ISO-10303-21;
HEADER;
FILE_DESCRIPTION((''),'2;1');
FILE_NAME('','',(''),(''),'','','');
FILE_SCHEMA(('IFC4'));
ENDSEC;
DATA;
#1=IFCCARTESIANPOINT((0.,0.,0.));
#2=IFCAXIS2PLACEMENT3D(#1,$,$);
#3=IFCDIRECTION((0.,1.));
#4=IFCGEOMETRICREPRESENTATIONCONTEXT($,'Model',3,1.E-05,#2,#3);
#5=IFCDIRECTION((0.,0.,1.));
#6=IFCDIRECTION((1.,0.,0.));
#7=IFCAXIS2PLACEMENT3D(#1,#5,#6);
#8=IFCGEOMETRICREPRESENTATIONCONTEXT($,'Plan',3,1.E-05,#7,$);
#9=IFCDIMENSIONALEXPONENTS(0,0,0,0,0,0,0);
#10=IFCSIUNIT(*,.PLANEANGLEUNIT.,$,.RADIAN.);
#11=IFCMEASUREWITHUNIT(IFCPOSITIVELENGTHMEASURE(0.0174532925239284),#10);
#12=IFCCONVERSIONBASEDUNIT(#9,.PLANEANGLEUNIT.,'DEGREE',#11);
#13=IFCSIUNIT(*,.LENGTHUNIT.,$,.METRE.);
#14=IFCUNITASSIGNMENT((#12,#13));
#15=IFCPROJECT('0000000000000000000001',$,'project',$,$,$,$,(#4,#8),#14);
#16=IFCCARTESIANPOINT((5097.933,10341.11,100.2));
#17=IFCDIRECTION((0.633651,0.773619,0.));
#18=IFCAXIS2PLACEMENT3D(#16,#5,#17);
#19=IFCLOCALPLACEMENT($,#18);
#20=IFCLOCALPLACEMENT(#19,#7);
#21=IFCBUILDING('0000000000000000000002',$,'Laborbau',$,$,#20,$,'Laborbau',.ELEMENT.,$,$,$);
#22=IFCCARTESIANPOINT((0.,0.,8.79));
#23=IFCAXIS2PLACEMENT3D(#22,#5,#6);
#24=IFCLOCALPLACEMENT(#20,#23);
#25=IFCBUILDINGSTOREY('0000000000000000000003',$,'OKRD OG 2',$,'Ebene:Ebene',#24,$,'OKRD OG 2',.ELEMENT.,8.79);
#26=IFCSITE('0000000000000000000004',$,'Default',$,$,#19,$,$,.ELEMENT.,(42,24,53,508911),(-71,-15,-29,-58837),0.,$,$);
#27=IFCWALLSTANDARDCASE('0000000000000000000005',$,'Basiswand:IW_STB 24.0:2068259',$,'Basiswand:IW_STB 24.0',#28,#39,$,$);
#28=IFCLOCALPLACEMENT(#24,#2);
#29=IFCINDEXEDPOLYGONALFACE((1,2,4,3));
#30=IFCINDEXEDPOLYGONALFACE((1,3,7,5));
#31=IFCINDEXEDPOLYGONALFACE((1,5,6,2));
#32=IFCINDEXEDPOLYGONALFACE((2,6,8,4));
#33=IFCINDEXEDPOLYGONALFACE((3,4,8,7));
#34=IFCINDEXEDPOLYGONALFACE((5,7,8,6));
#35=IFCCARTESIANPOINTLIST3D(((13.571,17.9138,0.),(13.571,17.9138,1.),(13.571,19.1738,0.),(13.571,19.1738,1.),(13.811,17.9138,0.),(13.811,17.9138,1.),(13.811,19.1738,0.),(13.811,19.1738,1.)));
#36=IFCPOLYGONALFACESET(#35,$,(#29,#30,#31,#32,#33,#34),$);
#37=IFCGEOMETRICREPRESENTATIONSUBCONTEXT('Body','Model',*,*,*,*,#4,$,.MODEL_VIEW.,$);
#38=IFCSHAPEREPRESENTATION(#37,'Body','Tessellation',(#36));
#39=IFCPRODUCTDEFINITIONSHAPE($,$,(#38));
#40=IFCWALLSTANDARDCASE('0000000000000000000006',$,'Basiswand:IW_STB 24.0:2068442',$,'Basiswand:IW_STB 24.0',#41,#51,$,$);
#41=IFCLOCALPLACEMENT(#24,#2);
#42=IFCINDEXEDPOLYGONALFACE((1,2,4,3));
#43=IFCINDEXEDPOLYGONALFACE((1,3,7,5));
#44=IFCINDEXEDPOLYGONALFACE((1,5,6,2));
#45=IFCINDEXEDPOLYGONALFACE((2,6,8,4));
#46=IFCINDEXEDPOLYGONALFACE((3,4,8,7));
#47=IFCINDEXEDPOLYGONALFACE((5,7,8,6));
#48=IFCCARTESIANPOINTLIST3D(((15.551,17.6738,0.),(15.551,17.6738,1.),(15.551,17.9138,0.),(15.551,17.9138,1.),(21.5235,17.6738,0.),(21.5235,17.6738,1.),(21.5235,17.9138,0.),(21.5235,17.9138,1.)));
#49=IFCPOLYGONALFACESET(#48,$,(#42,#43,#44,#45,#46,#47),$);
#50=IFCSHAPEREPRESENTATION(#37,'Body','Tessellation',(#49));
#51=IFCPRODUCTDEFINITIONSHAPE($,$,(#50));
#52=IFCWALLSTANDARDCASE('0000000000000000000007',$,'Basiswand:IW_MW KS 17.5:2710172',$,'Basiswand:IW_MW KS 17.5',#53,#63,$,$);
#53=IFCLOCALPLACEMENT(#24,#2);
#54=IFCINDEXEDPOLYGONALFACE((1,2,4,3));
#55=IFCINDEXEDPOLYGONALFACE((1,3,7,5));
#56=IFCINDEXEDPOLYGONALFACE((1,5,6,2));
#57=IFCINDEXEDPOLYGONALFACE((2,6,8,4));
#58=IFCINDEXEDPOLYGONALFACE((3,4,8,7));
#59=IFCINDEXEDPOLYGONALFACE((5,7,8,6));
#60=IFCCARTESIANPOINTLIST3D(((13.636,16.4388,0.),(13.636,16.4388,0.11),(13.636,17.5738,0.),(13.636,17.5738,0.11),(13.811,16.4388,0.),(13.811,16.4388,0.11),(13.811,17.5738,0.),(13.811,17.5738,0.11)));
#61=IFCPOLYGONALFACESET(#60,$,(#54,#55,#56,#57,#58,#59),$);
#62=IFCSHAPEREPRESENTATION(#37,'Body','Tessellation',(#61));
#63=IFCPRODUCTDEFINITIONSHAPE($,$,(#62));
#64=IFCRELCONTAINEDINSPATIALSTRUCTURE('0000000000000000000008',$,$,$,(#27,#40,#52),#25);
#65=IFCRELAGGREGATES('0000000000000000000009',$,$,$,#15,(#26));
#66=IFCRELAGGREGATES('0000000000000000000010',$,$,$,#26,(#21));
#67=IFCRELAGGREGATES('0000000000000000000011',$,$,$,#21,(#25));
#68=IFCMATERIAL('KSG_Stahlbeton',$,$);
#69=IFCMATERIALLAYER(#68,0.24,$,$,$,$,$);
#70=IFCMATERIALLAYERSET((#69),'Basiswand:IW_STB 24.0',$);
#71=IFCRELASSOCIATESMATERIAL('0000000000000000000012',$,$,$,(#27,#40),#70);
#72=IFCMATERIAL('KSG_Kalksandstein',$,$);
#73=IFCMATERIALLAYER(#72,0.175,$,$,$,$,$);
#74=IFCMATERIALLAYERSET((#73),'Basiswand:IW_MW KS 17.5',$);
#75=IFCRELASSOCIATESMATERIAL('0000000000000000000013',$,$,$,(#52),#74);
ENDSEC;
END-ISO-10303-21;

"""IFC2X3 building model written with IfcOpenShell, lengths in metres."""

from ifc_helpers import new_model, entity, si_unit, converted_unit, direction, frame, frame_2d, origin, origin_with_axes, place, context, subcontext, project, spatial, rectangle, extrude, material, layer, layer_set, layer_usage, element, save


model = new_model("IFC2X3")

# Units and contexts
model_context = context("Model", 3, precision=1e-05, world=origin(), true_north=direction((0.0, 1.0)))
plan_context = context("Plan", 3, precision=1e-05, world=origin_with_axes())
body_context = subcontext(model_context, "Body", "Model", "MODEL_VIEW")
ifc_project = project(units=[converted_unit("PLANEANGLEUNIT", "DEGREE", entity("IfcPositiveLengthMeasure", 0.0174532925239284), si_unit("PLANEANGLEUNIT", "RADIAN"), dimensions=[0, 0, 0, 0, 0, 0, 0]), si_unit("LENGTHUNIT", "METRE")], contexts=[model_context, plan_context])

# Site, building, storey
site_placement = place(None, frame((5097.933, 10341.11, 100.2), z_axis=(0.0, 0.0, 1.0), x_axis=(0.633651, 0.773619, 0.0)))
site = spatial("IfcSite", under=ifc_project, at=site_placement, Name="Default", CompositionType="ELEMENT", RefLatitude=(42, 24, 53, 508911), RefLongitude=(-71, -15, -29, -58837), RefElevation=0.0)
building_placement = place(site_placement, origin_with_axes())
building = spatial("IfcBuilding", under=site, at=building_placement, Name="Laborbau", LongName="Laborbau", CompositionType="ELEMENT")
storey_placement = place(building_placement, frame((0.0, 0.0, 8.79), z_axis=(0.0, 0.0, 1.0), x_axis=(1.0, 0.0, 0.0)))
storey = spatial("IfcBuildingStorey", under=building, at=storey_placement, Name="OKRD OG 2", ObjectType="Ebene:Ebene", LongName="OKRD OG 2", CompositionType="ELEMENT", Elevation=8.79)

# Shared definitions
ifc_material_1 = material(Name="KSG_Kalksandstein")
ifc_layer_1 = layer(ifc_material_1, 0.175)
ifc_layer_set_1 = layer_set([ifc_layer_1], Name="Basiswand:IW_MW KS 17.5")

# Walls
ifc_material_2 = material(Name="KSG_Stahlbeton")
ifc_layer_2 = layer(ifc_material_2, 0.24)
ifc_layer_set_2 = layer_set([ifc_layer_2], Name="Basiswand:IW_STB 24.0")
ifc_layer_usage_1 = layer_usage(ifc_layer_set_2, "AXIS2", "NEGATIVE", 0.12)
wall_1_placement = place(storey_placement, frame((13.691, 19.1738, 0.0), z_axis=(0.0, 0.0, 1.0), x_axis=(0.0, -1.0, 0.0)))
element("IfcWallStandardCase", 1, at=wall_1_placement, inside=storey, material=ifc_layer_usage_1, Name="Basiswand:IW_STB 24.0:2068259", ObjectType="Basiswand:IW_STB 24.0", context=body_context, shape_type="SweptSolid", body=[
    extrude(rectangle(XDim=1.26, YDim=0.24, at=frame_2d((0.63, 0.0), x_axis=(-1.0, 0.0))), origin(), (0.0, 0.0, 1.0), 1.0),
])
ifc_layer_usage_2 = layer_usage(ifc_layer_set_2, "AXIS2", "NEGATIVE", 0.12)
wall_2_placement = place(storey_placement, frame((15.551, 17.7938, 0.0), z_axis=(0.0, 0.0, 1.0), x_axis=(1.0, 0.0, 0.0)))
element("IfcWallStandardCase", 2, at=wall_2_placement, inside=storey, material=ifc_layer_usage_2, Name="Basiswand:IW_STB 24.0:2068442", ObjectType="Basiswand:IW_STB 24.0", context=body_context, shape_type="SweptSolid", body=[
    extrude(rectangle(XDim=5.9725, YDim=0.24, at=frame_2d((2.9863, 0.0), x_axis=(-1.0, 0.0))), origin(), (0.0, 0.0, 1.0), 1.0),
])
ifc_layer_usage_3 = layer_usage(ifc_layer_set_1, "AXIS2", "NEGATIVE", 0.0875)
wall_3_placement = place(storey_placement, frame((13.7235, 16.4388, 0.0), z_axis=(0.0, 0.0, 1.0), x_axis=(0.0, 1.0, 0.0)))
element("IfcWallStandardCase", 3, at=wall_3_placement, inside=storey, material=ifc_layer_usage_3, Name="Basiswand:IW_MW KS 17.5:2710172", ObjectType="Basiswand:IW_MW KS 17.5", context=body_context, shape_type="SweptSolid", body=[
    extrude(rectangle(XDim=1.135, YDim=0.175, at=frame_2d((0.5675, 0.0), x_axis=(-1.0, 0.0))), origin(), (0.0, 0.0, 1.0), 0.11),
])

save(model, "model.ifc")
